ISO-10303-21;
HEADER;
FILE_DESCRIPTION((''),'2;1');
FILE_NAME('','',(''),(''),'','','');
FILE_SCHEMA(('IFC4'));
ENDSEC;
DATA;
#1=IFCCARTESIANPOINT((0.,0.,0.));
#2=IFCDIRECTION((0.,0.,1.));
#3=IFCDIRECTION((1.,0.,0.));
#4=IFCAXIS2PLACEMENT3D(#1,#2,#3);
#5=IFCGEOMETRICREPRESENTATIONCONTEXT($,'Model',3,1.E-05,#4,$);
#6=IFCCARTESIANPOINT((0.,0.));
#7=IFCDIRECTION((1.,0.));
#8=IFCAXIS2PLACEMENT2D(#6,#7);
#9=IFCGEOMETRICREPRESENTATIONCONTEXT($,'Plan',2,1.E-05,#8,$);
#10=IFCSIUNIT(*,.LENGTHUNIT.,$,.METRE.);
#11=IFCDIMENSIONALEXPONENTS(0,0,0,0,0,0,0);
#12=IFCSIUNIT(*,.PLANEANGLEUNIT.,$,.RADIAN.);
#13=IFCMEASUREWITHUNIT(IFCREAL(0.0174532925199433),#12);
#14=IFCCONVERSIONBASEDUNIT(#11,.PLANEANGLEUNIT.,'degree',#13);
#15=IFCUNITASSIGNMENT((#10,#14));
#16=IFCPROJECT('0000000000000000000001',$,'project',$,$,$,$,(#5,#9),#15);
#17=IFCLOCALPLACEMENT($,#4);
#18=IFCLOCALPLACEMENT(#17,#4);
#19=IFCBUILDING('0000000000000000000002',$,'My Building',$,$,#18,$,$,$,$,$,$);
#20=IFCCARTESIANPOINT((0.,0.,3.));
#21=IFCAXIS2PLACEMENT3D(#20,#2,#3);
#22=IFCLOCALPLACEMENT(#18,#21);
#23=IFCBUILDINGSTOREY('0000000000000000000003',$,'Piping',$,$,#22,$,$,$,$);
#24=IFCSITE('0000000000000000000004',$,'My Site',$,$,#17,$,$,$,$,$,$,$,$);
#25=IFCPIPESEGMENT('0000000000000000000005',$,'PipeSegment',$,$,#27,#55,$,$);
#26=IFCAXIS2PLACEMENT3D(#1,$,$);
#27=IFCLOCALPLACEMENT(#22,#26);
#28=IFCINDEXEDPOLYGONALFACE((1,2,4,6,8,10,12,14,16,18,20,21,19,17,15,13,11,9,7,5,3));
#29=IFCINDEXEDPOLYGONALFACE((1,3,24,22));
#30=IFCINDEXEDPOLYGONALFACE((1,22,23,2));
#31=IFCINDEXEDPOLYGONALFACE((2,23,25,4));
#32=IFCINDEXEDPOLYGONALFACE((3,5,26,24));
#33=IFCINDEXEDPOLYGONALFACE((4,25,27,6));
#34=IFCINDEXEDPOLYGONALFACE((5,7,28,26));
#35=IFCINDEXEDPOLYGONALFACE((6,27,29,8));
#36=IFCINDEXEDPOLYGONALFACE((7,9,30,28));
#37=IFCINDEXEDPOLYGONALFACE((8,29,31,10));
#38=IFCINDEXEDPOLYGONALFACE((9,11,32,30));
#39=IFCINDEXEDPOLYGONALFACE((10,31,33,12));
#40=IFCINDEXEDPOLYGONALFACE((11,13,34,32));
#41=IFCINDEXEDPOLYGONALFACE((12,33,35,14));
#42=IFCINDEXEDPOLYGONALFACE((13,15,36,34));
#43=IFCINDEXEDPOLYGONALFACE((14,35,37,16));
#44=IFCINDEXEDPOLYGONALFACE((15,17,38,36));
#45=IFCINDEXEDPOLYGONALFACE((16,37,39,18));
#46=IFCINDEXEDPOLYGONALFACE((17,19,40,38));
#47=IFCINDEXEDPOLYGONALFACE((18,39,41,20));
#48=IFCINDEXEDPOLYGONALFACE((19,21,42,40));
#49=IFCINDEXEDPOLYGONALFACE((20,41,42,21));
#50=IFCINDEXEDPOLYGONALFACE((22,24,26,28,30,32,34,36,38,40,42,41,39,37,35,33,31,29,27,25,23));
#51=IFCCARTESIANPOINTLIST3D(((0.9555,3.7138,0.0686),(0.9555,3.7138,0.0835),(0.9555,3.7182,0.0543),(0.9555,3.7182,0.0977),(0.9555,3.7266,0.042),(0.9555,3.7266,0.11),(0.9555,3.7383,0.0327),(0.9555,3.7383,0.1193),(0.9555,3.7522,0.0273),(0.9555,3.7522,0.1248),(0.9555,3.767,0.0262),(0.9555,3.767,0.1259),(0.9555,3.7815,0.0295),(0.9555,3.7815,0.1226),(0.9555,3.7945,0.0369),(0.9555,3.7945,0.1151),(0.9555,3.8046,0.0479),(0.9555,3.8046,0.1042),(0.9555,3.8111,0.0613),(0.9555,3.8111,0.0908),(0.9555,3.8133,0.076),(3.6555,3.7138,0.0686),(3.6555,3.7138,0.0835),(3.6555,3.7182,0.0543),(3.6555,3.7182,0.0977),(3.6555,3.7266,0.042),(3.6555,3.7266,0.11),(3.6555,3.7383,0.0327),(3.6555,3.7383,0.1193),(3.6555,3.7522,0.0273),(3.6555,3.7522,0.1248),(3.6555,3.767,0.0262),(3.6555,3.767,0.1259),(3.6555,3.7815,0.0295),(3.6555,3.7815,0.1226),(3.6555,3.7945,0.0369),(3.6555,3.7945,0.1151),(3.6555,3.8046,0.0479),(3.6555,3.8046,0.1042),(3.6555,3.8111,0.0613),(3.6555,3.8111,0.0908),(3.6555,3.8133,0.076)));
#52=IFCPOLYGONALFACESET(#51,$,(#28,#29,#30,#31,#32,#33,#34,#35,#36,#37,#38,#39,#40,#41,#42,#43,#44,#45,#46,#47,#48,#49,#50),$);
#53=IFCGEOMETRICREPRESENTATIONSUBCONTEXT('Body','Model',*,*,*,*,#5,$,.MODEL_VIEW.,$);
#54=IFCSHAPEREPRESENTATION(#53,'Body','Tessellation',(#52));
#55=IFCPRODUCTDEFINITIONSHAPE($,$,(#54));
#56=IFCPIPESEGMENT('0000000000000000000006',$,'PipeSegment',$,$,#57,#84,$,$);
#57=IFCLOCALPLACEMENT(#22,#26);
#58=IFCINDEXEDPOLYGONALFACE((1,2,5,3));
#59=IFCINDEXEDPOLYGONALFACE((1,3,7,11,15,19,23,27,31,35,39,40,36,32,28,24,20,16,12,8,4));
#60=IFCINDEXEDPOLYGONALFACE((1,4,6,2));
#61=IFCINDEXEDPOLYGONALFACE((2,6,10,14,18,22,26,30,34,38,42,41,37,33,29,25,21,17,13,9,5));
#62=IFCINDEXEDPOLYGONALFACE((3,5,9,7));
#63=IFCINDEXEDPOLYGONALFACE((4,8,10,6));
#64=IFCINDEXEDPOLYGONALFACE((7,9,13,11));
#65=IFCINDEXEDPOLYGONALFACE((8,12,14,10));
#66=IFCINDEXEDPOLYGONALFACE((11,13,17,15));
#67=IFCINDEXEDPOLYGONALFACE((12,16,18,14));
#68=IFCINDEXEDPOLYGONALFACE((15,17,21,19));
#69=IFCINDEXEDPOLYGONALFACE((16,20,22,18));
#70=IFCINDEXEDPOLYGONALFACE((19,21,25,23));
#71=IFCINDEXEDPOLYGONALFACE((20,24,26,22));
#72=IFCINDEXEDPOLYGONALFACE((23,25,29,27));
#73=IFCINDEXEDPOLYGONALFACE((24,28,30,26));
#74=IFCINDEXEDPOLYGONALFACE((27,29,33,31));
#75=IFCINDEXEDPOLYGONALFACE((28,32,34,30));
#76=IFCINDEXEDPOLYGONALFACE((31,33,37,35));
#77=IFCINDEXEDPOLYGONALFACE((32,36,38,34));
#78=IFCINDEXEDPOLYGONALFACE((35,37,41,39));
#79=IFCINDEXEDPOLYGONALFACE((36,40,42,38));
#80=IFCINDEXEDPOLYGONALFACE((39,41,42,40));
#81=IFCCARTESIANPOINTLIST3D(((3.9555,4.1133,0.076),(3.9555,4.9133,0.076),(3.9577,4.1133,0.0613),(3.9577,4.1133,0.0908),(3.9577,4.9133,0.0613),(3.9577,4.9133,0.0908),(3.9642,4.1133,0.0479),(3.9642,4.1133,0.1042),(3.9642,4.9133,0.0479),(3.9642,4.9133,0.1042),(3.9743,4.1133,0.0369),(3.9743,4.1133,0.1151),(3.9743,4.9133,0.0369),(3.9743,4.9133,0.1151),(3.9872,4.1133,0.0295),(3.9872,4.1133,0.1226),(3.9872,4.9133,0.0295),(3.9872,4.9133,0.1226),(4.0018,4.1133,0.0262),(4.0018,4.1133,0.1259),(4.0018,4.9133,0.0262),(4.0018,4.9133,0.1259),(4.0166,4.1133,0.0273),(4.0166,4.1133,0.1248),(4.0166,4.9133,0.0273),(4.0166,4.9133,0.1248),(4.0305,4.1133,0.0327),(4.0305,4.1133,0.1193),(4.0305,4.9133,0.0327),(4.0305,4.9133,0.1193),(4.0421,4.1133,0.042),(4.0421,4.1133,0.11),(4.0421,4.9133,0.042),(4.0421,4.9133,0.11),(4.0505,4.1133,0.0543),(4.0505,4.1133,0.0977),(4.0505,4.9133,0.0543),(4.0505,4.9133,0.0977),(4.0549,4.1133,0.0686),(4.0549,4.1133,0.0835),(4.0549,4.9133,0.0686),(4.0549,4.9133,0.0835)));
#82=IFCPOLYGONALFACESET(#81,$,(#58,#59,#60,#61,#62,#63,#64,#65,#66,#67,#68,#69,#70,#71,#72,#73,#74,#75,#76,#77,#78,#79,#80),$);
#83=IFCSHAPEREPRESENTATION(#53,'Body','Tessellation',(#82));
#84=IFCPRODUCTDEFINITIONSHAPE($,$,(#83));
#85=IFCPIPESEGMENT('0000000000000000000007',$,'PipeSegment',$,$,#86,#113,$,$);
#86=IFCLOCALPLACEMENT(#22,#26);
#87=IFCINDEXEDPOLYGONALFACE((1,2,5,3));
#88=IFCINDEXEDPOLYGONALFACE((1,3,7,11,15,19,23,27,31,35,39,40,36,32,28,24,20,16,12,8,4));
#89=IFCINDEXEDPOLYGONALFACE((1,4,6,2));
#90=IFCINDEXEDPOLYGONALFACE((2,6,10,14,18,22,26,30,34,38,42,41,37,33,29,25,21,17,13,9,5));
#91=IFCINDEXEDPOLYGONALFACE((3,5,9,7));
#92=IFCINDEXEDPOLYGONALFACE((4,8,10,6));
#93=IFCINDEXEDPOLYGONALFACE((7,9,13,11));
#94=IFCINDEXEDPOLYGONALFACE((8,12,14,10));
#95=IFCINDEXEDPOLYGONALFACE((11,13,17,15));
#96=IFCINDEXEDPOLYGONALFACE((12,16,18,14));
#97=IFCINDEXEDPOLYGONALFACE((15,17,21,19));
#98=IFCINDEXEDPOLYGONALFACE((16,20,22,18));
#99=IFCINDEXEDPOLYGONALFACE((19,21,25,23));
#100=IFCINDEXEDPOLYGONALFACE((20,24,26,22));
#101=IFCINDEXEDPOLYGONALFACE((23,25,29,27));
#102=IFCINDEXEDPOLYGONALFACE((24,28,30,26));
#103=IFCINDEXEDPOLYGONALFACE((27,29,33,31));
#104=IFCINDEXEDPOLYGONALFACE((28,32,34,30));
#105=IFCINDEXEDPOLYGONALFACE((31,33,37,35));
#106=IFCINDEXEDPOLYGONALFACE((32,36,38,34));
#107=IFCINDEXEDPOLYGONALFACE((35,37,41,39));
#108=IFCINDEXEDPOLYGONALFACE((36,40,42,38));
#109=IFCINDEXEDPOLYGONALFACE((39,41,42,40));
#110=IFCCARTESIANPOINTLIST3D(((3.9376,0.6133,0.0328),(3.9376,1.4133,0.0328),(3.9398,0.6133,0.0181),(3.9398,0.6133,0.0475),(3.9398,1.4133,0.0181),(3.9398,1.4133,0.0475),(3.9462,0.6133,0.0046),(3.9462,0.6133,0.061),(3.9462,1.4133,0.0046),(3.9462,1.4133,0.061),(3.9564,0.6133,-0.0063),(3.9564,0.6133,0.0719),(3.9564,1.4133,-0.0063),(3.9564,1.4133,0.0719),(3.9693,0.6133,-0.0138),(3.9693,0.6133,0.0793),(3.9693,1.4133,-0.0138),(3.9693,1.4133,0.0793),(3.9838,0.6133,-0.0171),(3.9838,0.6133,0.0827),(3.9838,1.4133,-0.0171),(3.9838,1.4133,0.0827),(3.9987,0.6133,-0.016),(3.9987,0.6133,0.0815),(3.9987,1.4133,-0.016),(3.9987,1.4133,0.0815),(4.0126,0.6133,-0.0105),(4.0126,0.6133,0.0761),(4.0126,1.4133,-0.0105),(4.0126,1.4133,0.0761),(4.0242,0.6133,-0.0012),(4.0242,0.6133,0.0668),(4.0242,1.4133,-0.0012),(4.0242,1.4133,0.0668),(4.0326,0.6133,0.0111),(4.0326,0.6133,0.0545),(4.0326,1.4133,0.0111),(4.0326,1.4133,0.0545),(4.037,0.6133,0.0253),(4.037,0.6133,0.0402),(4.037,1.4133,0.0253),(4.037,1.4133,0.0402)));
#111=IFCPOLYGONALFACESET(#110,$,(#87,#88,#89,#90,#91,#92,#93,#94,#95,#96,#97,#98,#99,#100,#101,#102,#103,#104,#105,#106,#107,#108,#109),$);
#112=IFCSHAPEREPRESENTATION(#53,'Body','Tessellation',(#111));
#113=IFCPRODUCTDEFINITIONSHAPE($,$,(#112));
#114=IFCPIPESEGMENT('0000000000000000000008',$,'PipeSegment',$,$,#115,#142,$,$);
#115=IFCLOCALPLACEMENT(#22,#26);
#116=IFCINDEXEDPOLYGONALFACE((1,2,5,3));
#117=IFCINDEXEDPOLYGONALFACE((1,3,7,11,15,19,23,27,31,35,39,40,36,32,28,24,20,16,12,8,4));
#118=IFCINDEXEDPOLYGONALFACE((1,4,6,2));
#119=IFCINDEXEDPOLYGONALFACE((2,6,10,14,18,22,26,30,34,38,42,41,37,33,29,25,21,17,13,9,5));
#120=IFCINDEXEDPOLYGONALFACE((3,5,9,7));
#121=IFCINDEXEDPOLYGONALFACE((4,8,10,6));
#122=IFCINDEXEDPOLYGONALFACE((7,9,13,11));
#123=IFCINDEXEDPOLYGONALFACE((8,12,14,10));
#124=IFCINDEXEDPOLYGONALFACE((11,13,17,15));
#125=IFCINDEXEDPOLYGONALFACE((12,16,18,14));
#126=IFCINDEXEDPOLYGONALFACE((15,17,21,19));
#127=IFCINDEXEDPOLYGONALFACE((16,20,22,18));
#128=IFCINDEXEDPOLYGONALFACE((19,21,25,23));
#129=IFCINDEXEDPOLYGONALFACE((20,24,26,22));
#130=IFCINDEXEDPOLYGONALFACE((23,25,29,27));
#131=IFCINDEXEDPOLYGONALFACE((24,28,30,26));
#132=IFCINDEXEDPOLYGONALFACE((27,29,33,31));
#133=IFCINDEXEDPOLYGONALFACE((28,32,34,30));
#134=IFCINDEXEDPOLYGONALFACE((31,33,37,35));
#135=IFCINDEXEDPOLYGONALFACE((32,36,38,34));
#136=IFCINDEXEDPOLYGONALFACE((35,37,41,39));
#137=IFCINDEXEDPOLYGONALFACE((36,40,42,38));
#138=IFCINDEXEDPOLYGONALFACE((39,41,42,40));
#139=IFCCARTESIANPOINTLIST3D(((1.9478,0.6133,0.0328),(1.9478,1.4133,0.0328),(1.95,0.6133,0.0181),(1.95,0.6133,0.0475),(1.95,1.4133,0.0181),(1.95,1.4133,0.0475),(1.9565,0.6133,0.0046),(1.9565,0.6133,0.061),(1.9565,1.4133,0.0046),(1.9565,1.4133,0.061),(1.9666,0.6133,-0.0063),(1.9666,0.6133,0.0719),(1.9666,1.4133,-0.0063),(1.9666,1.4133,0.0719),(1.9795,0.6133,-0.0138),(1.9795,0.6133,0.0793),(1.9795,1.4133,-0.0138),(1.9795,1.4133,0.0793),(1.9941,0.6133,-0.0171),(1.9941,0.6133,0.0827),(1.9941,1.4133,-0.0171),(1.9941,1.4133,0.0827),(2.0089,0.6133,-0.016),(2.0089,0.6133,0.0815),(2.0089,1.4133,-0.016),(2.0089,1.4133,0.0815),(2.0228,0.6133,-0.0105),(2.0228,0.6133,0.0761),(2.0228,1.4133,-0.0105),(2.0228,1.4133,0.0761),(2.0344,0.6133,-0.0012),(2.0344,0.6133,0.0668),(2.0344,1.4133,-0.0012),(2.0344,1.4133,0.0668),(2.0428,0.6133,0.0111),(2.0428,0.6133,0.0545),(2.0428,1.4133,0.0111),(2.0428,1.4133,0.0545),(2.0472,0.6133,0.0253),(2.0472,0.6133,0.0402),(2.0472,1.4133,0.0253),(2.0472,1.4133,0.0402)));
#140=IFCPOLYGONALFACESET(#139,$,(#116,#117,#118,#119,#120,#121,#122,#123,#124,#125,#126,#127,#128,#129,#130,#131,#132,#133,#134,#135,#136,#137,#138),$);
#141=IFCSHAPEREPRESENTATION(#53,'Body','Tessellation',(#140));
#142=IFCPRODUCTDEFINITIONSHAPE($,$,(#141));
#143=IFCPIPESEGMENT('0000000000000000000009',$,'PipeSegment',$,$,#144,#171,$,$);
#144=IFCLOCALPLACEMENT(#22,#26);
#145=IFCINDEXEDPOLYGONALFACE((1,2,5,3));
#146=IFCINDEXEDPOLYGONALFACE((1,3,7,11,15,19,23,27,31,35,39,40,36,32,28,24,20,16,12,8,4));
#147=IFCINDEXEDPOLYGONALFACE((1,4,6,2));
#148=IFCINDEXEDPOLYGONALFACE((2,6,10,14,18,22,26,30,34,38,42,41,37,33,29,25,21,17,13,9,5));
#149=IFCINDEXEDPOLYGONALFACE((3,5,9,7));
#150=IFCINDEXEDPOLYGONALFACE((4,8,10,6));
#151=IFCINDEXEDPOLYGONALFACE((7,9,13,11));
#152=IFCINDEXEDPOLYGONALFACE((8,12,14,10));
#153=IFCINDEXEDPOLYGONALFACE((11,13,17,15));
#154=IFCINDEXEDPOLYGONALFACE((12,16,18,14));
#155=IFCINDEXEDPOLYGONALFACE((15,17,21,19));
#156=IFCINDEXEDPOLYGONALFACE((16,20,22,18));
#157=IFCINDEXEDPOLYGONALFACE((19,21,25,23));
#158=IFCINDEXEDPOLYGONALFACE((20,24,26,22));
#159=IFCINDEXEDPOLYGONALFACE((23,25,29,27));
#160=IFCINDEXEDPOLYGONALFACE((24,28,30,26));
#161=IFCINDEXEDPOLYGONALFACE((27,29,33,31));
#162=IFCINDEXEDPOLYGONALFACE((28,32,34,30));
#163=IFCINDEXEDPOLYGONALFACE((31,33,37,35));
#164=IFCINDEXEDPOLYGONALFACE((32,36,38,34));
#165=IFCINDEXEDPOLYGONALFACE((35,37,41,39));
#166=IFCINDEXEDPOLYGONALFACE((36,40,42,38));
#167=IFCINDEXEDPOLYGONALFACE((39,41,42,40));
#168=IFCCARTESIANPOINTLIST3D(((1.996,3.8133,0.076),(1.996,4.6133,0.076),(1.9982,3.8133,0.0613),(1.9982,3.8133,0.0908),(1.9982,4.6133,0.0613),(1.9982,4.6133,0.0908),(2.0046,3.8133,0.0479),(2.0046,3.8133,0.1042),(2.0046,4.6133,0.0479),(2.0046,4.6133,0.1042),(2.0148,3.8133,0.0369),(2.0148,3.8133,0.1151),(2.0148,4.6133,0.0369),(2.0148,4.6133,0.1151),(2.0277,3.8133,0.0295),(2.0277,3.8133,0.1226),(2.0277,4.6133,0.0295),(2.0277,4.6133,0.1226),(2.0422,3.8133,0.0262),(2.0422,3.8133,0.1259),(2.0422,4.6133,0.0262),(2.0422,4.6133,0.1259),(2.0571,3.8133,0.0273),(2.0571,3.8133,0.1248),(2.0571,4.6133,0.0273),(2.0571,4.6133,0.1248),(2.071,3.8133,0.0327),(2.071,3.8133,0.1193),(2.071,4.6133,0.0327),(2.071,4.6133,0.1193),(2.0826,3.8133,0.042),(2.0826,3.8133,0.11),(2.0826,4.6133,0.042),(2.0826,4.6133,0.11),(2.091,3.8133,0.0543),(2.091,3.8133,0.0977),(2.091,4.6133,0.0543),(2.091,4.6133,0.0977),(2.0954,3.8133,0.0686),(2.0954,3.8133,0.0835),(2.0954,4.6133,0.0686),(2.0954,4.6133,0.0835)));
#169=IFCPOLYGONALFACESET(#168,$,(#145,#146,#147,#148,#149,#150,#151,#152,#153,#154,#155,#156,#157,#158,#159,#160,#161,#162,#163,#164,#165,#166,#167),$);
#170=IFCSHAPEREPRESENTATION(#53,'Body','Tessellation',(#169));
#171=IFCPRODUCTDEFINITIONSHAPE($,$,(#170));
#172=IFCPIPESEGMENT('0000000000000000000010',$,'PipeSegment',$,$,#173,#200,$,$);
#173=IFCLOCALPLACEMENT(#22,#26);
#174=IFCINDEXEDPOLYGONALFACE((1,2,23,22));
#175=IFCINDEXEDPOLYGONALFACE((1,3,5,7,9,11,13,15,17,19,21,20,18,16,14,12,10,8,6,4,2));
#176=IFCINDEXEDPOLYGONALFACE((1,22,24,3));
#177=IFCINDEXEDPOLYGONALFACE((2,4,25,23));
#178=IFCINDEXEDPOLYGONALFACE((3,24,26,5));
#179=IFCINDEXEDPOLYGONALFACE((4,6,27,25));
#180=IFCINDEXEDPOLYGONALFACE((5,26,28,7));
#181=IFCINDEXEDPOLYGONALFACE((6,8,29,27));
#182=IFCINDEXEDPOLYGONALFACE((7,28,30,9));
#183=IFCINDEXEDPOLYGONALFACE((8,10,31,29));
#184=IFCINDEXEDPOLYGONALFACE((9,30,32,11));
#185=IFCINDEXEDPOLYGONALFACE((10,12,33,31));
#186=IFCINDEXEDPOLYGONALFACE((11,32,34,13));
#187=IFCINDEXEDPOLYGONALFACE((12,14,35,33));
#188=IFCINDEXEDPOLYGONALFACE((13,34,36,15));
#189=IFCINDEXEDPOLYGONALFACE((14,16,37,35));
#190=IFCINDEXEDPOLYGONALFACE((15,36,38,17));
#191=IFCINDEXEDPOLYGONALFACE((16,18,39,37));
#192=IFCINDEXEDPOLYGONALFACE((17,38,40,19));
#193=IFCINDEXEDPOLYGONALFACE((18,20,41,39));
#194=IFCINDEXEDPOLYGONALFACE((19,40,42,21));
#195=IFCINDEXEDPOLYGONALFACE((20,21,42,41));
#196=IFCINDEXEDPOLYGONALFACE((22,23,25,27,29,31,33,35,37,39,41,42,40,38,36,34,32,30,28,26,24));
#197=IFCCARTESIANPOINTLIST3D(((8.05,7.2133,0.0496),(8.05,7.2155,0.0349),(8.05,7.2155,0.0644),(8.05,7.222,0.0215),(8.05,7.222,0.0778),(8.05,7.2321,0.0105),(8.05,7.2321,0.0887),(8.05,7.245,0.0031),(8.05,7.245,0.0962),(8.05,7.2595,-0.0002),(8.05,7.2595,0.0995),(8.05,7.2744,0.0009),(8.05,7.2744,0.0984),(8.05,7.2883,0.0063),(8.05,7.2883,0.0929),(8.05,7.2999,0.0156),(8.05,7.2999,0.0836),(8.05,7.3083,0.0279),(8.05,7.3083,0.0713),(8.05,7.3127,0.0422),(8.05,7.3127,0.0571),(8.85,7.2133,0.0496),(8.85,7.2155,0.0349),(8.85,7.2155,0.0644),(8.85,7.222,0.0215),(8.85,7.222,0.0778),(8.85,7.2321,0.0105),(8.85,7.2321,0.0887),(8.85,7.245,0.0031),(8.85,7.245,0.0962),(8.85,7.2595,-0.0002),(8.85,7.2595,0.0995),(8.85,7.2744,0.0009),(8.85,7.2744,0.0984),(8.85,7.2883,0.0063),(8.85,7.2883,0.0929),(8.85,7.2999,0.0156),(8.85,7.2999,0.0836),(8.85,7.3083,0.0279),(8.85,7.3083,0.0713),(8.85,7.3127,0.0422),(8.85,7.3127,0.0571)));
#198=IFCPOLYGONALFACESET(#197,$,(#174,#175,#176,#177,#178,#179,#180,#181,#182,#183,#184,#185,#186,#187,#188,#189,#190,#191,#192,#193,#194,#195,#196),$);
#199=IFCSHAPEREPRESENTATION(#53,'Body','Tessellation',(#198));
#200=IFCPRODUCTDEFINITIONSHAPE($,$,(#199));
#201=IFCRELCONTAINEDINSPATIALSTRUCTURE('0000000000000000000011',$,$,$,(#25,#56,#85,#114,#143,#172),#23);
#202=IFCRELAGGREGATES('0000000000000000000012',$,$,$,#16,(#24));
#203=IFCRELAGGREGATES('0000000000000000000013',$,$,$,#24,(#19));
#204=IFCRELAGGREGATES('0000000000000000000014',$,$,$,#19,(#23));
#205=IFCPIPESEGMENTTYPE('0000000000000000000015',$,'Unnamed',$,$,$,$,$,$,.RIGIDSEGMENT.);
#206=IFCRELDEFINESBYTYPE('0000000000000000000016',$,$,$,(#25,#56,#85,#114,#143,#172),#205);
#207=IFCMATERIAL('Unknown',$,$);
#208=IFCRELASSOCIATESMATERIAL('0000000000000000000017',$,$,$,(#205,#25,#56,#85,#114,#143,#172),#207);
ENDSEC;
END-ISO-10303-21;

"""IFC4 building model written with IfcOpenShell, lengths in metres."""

from ifc_helpers import new_model, entity, si_unit, converted_unit, frame, origin_with_axes, origin_2d_with_axis, place, context, subcontext, project, spatial, circle, extrude, material, material_profile, profile_set, profile_usage, type_object, element, save


model = new_model("IFC4")

# Units and contexts
model_context = context("Model", 3, precision=1e-05, world=origin_with_axes())
plan_context = context("Plan", 2, precision=1e-05, world=origin_2d_with_axis())
body_context = subcontext(model_context, "Body", "Model", "MODEL_VIEW")
ifc_project = project(units=[si_unit("LENGTHUNIT", "METRE"), converted_unit("PLANEANGLEUNIT", "degree", entity("IfcReal", 0.0174532925199433), si_unit("PLANEANGLEUNIT", "RADIAN"), dimensions=[0, 0, 0, 0, 0, 0, 0])], contexts=[model_context, plan_context])

# Site, building, storey
site_placement = place(None, origin_with_axes())
site = spatial("IfcSite", under=ifc_project, at=site_placement, Name="My Site")
building_placement = place(site_placement, origin_with_axes())
building = spatial("IfcBuilding", under=site, at=building_placement, Name="My Building")
storey_placement = place(building_placement, frame((0.0, 0.0, 3.0), z_axis=(0.0, 0.0, 1.0), x_axis=(1.0, 0.0, 0.0)))
storey = spatial("IfcBuildingStorey", under=building, at=storey_placement, Name="Piping")

# Pipe segments
ifc_material = material(Name="Unknown")
ifc_material_profile = material_profile(ifc_material, circle(Radius=0.05))
ifc_profile_set = profile_set([ifc_material_profile])
pipe_segment_type = type_object("IfcPipeSegmentType", Name="Unnamed", PredefinedType="RIGIDSEGMENT", material=ifc_profile_set)
ifc_profile_usage_1 = profile_usage(ifc_profile_set, cardinal=10)
pipe_segment_1_placement = place(storey_placement, frame((0.9555, 3.7633, 0.076), z_axis=(1.0, 0.0, 0.0), x_axis=(0.0, 1.0, 0.0)))
element("IfcPipeSegment", 1, at=pipe_segment_1_placement, inside=storey, type_object=pipe_segment_type, material=ifc_profile_usage_1, Name="PipeSegment", context=body_context, shape_type="SweptSolid", body=[
    extrude(circle(Radius=0.05), origin_with_axes(), (0.0, 0.0, 1.0), 2.7),
])
ifc_profile_usage_2 = profile_usage(ifc_profile_set, cardinal=8)
pipe_segment_2_placement = place(storey_placement, frame((4.0055, 4.1133, 0.126), z_axis=(0.0, 1.0, 0.0), x_axis=(-1.0, 0.0, 0.0)))
element("IfcPipeSegment", 2, at=pipe_segment_2_placement, inside=storey, type_object=pipe_segment_type, material=ifc_profile_usage_2, Name="PipeSegment", context=body_context, shape_type="SweptSolid", body=[
    extrude(circle(Radius=0.05), frame((0.0, -0.05, 0.0), z_axis=(0.0, 0.0, 1.0), x_axis=(1.0, 0.0, 0.0)), (0.0, 0.0, 1.0), 0.8),
])
ifc_profile_usage_3 = profile_usage(ifc_profile_set, cardinal=8)
pipe_segment_3_placement = place(storey_placement, frame((3.9876, 0.6133, 0.0828), z_axis=(0.0, 1.0, 0.0), x_axis=(-1.0, 0.0, 0.0)))
element("IfcPipeSegment", 3, at=pipe_segment_3_placement, inside=storey, type_object=pipe_segment_type, material=ifc_profile_usage_3, Name="PipeSegment", context=body_context, shape_type="SweptSolid", body=[
    extrude(circle(Radius=0.05), frame((0.0, -0.05, 0.0), z_axis=(0.0, 0.0, 1.0), x_axis=(1.0, 0.0, 0.0)), (0.0, 0.0, 1.0), 0.8),
])
ifc_profile_usage_4 = profile_usage(ifc_profile_set, cardinal=8)
pipe_segment_4_placement = place(storey_placement, frame((1.9978, 0.6133, 0.0828), z_axis=(0.0, 1.0, 0.0), x_axis=(-1.0, 0.0, 0.0)))
element("IfcPipeSegment", 4, at=pipe_segment_4_placement, inside=storey, type_object=pipe_segment_type, material=ifc_profile_usage_4, Name="PipeSegment", context=body_context, shape_type="SweptSolid", body=[
    extrude(circle(Radius=0.05), frame((0.0, -0.05, 0.0), z_axis=(0.0, 0.0, 1.0), x_axis=(1.0, 0.0, 0.0)), (0.0, 0.0, 1.0), 0.8),
])
ifc_profile_usage_5 = profile_usage(ifc_profile_set, cardinal=8)
pipe_segment_5_placement = place(storey_placement, frame((2.046, 3.8133, 0.126), z_axis=(0.0, 1.0, 0.0), x_axis=(-1.0, 0.0, 0.0)))
element("IfcPipeSegment", 5, at=pipe_segment_5_placement, inside=storey, type_object=pipe_segment_type, material=ifc_profile_usage_5, Name="PipeSegment", context=body_context, shape_type="SweptSolid", body=[
    extrude(circle(Radius=0.05), frame((0.0, -0.05, 0.0), z_axis=(0.0, 0.0, 1.0), x_axis=(1.0, 0.0, 0.0)), (0.0, 0.0, 1.0), 0.8),
])
ifc_profile_usage_6 = profile_usage(ifc_profile_set, cardinal=8)
pipe_segment_6_placement = place(storey_placement, frame((8.85, 7.2633, 0.0996), z_axis=(-1.0, 0.0, 0.0), x_axis=(0.0, -1.0, 0.0)))
element("IfcPipeSegment", 6, at=pipe_segment_6_placement, inside=storey, type_object=pipe_segment_type, material=ifc_profile_usage_6, Name="PipeSegment", context=body_context, shape_type="SweptSolid", body=[
    extrude(circle(Radius=0.05), frame((0.0, -0.05, 0.0), z_axis=(0.0, 0.0, 1.0), x_axis=(1.0, 0.0, 0.0)), (0.0, 0.0, 1.0), 0.8),
])

save(model, "model.ifc")
